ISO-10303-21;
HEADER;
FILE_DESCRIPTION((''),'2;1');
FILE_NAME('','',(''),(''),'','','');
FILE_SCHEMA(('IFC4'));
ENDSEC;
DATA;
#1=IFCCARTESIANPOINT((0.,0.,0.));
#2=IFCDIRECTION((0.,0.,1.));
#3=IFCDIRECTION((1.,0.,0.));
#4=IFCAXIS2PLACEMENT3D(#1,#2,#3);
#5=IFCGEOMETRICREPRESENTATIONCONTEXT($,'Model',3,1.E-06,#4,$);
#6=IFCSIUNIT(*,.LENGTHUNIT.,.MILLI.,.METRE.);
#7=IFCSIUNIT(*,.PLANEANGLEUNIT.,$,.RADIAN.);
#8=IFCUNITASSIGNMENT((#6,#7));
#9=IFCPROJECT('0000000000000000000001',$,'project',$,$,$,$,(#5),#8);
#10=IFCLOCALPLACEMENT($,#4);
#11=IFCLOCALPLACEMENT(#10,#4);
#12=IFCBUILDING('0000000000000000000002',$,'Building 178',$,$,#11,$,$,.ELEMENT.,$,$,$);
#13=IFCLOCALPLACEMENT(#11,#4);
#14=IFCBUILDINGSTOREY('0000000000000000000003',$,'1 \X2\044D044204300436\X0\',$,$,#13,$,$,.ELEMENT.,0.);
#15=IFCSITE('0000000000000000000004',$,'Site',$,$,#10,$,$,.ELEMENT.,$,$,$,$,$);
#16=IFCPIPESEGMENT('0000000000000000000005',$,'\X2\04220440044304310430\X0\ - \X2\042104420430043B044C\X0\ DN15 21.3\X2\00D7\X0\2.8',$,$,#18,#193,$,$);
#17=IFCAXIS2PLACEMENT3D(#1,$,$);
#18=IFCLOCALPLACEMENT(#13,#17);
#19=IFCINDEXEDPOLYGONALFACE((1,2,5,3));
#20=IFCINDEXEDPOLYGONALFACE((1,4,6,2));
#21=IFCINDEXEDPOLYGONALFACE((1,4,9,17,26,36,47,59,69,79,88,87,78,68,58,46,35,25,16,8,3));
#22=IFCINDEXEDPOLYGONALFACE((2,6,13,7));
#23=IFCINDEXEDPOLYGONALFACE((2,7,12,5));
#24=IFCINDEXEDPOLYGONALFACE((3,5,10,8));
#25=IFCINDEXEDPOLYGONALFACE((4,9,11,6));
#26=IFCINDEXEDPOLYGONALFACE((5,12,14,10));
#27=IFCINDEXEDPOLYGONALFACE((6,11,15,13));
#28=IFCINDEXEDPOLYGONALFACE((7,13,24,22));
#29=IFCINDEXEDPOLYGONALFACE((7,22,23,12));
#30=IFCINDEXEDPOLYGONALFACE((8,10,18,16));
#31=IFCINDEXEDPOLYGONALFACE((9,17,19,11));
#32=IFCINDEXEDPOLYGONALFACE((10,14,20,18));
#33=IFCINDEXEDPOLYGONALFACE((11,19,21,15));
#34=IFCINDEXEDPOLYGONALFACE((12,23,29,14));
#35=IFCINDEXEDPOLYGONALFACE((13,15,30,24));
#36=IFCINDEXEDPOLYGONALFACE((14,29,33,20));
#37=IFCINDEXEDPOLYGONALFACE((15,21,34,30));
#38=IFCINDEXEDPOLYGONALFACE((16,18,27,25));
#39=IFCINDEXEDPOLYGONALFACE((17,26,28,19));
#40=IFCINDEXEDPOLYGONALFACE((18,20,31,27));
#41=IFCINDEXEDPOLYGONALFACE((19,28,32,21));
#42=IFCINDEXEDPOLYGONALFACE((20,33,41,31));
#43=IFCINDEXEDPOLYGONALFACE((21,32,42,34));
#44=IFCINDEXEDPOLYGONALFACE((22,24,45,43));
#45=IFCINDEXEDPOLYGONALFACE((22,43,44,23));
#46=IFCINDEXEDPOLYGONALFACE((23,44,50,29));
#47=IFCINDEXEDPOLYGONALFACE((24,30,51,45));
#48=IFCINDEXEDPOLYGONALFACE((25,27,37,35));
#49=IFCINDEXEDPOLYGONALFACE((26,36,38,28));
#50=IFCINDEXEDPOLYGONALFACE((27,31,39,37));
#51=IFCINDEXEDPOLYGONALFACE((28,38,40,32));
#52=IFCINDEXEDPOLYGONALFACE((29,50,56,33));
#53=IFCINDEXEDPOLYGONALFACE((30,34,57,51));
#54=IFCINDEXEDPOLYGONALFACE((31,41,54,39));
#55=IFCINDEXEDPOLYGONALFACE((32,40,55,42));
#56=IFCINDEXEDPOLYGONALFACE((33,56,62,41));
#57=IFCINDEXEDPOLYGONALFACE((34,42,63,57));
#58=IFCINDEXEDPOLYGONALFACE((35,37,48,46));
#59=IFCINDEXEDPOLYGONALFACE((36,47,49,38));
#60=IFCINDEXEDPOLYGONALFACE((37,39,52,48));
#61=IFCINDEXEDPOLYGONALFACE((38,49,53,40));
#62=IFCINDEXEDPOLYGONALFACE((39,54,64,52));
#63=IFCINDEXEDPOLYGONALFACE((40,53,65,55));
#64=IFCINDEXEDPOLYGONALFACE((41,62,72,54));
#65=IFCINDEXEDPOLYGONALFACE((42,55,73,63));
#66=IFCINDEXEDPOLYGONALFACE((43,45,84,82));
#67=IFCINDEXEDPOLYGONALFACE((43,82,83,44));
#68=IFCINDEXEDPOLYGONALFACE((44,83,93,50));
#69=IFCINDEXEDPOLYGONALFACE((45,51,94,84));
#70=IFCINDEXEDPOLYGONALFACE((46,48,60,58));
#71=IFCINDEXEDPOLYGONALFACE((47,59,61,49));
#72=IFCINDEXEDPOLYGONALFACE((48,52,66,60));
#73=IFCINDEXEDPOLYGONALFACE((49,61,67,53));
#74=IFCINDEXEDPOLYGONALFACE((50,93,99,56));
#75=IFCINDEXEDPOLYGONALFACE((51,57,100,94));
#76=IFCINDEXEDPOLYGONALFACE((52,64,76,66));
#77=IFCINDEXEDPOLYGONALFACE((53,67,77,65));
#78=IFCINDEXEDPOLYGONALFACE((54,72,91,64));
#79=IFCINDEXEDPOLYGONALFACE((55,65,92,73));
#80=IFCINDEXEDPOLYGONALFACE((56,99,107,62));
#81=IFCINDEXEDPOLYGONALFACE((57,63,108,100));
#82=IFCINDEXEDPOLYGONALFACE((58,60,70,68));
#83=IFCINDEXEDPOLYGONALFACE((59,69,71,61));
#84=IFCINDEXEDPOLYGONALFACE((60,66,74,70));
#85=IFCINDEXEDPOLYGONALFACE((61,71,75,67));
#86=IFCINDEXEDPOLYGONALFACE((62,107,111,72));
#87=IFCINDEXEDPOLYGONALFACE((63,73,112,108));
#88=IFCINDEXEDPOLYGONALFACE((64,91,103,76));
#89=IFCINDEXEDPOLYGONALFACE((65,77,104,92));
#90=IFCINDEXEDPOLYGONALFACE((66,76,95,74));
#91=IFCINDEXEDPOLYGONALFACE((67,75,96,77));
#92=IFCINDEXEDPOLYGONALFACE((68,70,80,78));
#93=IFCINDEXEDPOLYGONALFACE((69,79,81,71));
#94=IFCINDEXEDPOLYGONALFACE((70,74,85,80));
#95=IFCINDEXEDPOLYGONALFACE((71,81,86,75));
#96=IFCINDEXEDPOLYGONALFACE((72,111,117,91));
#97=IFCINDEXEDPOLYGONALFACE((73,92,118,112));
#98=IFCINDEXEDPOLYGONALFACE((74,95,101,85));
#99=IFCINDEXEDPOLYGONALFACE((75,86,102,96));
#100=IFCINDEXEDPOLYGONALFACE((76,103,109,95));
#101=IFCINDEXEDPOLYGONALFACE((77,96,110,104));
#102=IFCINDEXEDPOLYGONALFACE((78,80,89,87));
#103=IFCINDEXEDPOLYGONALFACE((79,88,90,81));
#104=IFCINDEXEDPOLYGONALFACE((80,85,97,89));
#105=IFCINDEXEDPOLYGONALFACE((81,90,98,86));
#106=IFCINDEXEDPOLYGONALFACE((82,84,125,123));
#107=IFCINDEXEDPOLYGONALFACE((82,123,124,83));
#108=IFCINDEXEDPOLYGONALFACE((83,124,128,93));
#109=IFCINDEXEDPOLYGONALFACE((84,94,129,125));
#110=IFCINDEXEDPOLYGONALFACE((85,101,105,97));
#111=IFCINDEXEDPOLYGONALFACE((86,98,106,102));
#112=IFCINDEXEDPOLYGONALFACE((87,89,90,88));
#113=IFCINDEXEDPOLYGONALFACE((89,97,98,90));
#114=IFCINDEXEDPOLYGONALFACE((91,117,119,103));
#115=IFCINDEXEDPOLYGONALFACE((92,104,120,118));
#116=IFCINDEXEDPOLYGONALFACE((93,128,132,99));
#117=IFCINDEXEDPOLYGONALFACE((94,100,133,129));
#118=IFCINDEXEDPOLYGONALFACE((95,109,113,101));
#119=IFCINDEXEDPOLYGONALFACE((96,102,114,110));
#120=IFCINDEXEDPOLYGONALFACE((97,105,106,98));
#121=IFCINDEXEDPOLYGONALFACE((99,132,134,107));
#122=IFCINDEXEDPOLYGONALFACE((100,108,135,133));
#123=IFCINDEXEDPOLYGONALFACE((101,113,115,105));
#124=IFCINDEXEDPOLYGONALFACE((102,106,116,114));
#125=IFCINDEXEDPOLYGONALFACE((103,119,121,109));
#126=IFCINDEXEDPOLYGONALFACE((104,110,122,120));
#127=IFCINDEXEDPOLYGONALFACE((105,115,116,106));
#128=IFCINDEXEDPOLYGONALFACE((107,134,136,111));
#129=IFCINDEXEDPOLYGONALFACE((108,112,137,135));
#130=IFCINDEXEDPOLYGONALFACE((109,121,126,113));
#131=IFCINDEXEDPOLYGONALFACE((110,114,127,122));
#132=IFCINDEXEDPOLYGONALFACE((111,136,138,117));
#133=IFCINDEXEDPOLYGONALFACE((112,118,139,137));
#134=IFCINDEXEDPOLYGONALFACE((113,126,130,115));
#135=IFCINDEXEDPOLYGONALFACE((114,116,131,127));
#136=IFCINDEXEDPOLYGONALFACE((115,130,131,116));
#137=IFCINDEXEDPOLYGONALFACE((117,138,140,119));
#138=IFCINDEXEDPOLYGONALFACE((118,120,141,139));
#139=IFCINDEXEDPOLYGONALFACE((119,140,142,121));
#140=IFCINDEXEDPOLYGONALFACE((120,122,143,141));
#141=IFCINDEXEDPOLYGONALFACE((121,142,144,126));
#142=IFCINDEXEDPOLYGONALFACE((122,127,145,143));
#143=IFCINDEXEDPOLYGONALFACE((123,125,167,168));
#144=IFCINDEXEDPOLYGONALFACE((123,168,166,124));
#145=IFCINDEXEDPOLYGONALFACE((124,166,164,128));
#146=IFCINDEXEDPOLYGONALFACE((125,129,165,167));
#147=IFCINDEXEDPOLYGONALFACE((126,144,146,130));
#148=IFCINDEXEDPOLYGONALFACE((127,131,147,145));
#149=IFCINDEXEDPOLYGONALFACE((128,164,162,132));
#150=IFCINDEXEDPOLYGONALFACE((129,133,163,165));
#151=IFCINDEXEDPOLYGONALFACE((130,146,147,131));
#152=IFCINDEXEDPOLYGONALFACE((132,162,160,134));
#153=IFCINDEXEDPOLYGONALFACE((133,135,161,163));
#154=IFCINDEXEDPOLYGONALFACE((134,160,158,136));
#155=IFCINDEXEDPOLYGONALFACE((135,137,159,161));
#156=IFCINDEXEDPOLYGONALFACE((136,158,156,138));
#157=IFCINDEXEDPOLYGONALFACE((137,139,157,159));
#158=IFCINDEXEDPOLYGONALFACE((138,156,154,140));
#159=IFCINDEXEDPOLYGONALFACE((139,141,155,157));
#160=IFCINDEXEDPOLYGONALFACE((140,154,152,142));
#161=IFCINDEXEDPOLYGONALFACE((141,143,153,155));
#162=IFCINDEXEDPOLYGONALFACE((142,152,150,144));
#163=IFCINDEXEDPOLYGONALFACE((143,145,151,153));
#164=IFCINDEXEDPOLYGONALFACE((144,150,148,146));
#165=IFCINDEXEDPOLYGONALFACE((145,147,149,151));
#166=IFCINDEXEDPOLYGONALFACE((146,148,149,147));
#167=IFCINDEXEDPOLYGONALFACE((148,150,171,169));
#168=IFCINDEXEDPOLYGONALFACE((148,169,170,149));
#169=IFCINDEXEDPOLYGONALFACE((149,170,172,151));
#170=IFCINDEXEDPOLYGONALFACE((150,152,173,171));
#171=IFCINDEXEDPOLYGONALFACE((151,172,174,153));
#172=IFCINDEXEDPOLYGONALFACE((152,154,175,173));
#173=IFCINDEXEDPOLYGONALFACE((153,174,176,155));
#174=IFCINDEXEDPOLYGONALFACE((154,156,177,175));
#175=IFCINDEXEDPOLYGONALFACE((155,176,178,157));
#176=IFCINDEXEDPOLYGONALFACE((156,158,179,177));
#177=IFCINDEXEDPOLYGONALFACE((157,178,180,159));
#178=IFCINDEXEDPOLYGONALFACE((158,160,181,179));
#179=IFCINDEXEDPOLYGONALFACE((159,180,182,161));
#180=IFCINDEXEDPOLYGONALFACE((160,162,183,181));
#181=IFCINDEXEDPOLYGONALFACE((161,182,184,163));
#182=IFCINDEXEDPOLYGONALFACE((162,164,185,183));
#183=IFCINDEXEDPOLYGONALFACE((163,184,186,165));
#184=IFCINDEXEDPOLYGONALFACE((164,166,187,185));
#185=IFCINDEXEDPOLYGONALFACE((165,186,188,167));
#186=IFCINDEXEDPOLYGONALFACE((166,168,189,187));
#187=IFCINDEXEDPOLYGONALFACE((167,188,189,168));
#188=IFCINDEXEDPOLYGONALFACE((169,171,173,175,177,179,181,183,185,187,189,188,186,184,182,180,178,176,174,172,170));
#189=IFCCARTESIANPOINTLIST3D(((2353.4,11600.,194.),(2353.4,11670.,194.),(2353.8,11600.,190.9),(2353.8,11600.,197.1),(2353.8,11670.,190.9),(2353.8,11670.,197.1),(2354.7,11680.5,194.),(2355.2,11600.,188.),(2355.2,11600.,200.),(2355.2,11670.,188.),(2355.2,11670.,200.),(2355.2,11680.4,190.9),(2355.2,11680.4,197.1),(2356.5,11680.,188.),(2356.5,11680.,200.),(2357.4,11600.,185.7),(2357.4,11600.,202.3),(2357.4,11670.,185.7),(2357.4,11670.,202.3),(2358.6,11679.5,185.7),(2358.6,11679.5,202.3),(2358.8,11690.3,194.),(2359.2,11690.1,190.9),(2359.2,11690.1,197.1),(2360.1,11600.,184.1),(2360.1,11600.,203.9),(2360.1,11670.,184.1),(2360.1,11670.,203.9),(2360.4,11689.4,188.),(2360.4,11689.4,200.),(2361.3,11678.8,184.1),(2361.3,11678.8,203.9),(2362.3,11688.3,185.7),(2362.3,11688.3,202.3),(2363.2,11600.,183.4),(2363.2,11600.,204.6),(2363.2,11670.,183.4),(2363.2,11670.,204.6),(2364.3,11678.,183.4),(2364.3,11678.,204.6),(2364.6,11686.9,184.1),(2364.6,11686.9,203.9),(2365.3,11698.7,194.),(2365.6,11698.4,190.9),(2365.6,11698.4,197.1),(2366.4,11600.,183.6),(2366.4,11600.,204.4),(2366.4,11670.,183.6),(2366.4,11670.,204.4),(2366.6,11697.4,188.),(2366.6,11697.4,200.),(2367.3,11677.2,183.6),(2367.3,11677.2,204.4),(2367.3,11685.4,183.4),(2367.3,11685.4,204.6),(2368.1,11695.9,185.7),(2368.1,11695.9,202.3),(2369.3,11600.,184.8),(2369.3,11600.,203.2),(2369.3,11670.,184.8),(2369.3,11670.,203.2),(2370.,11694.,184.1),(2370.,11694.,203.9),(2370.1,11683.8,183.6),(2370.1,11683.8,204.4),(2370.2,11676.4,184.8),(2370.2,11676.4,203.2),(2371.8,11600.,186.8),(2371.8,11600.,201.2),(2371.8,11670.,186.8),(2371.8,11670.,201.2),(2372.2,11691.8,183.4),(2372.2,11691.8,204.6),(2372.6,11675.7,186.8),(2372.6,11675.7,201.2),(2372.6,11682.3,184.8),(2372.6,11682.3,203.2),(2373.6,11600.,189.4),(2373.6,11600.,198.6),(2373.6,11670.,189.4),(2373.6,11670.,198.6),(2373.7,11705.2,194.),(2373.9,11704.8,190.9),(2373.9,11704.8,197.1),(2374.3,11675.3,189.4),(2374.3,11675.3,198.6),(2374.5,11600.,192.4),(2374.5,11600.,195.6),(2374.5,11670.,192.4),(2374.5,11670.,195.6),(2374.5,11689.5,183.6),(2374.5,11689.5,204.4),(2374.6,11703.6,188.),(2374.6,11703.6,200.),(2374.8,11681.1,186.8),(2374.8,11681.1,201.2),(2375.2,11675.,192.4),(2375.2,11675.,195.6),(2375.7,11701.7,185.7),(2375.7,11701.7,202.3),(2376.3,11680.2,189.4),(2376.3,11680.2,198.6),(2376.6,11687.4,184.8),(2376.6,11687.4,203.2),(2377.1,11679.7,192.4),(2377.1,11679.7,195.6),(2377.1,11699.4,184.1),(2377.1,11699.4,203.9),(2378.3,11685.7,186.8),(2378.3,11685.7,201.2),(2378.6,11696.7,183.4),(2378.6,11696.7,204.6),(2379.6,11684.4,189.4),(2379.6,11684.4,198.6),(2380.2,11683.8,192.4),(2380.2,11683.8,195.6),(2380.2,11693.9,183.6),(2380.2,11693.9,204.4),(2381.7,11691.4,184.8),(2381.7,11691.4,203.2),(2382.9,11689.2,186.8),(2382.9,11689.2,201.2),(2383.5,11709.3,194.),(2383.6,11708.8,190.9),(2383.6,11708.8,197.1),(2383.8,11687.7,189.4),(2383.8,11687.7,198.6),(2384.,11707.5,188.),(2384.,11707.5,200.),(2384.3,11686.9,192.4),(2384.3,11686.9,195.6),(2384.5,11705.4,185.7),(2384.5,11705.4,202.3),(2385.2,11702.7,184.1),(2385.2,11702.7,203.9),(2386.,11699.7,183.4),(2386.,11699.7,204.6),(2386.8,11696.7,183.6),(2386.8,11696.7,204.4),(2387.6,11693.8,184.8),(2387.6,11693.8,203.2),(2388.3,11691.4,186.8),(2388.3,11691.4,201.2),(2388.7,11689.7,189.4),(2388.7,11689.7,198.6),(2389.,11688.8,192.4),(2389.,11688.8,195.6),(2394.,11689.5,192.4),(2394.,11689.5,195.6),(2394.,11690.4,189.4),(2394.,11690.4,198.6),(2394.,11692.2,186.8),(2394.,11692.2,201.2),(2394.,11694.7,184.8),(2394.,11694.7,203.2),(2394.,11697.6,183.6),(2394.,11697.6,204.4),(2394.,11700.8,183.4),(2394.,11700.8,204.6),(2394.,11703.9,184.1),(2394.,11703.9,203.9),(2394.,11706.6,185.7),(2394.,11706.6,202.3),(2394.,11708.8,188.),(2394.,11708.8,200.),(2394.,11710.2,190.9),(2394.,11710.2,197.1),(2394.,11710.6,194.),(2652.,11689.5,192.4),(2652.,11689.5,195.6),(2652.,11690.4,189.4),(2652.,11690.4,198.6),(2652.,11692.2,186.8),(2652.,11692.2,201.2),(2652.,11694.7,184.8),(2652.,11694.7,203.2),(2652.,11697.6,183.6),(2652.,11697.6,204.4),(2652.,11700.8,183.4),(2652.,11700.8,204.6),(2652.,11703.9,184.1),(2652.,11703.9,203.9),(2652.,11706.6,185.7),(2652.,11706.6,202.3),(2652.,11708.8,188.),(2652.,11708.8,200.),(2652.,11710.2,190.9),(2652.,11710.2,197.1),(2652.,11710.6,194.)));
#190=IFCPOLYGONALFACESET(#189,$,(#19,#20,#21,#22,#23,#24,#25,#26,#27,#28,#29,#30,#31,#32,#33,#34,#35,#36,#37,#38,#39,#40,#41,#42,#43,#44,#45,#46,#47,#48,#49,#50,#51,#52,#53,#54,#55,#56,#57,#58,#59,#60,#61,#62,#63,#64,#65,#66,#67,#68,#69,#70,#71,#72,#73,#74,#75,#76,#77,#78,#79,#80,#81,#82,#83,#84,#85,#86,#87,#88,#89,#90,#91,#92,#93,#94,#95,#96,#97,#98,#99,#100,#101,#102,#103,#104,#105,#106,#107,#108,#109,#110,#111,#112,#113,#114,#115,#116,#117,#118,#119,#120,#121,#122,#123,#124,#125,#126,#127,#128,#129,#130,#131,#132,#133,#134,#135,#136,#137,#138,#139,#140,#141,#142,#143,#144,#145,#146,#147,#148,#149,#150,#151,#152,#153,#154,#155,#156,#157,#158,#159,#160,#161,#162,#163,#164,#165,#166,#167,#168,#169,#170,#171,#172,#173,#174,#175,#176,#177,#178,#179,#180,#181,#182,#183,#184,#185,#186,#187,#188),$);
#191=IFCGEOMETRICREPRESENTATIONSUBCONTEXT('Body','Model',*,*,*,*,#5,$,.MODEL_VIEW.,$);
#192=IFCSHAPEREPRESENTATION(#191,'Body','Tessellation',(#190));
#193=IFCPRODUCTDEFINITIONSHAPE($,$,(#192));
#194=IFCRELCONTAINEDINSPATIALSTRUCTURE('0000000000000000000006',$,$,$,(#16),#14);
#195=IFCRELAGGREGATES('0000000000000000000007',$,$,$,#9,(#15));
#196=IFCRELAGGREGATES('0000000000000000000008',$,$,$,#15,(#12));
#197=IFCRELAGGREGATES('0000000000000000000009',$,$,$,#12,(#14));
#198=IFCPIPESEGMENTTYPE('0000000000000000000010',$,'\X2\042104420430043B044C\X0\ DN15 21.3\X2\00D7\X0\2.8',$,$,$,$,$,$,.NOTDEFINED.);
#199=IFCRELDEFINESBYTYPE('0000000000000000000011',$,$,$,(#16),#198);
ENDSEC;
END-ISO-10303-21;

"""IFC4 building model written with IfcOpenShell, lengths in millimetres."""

from ifc_helpers import new_model, entity, si_unit, frame, origin_with_axes, place, context, subcontext, project, spatial, source, transform, mapped, type_object, element, save


model = new_model("IFC4")

# Units and contexts
model_context = context("Model", 3, precision=1e-06, world=origin_with_axes())
body_context = subcontext(model_context, "Body", "Model", "MODEL_VIEW")
ifc_project = project(units=[si_unit("LENGTHUNIT", "METRE", prefix="MILLI"), si_unit("PLANEANGLEUNIT", "RADIAN")], contexts=[model_context])

# Site, building, storey
site_placement = place(None, origin_with_axes())
site = spatial("IfcSite", under=ifc_project, at=site_placement, Name="Site", CompositionType="ELEMENT")
building_placement = place(site_placement, origin_with_axes())
building = spatial("IfcBuilding", under=site, at=building_placement, Name="Building 178", CompositionType="ELEMENT")
storey_placement = place(building_placement, origin_with_axes())
storey = spatial("IfcBuildingStorey", under=building, at=storey_placement, Name="1 этаж", CompositionType="ELEMENT", Elevation=0.0)

# Pipe segment
pipe_segment_type = type_object("IfcPipeSegmentType", Name="Сталь DN15 21.3×2.8", PredefinedType="NOTDEFINED")
shared_shape_1 = source(origin_with_axes(), body_context, "Body", "AdvancedSweptSolid", [
    entity("IfcSweptDiskSolid", entity("IfcIndexedPolyCurve", entity("IfcCartesianPointList3D", [[0.0, 0.0, 0.0], [0.0, 0.0, -70.0], [8.8, 0.0, -91.2], [30.0, 0.0, -100.0], [288.0, 0.0, -100.0]]), [entity("IfcLineIndex", [1, 2]), entity("IfcArcIndex", [2, 3, 4]), entity("IfcLineIndex", [4, 5])]), 10.7),
])
for number, where, z_axis, x_axis, name in (
    (1, (2364.0, 11600.0, 194.0), (0.0, -1.0, 0.0), (1.0, 0.0, 0.0), "Труба - Сталь DN15 21.3×2.8"),
):
    element("IfcPipeSegment", number, at=place(storey_placement, frame(where, z_axis=z_axis, x_axis=x_axis)), inside=storey, type_object=pipe_segment_type, Name=name, context=body_context, shape_type="MappedRepresentation", body=[
        mapped(shared_shape_1, transform((0.0, 0.0, 0.0), x_axis=(1.0, 0.0, 0.0), y_axis=(0.0, 1.0, 0.0), z_axis=(0.0, 0.0, 1.0), scale=1.0)),
    ])

save(model, "model.ifc")
